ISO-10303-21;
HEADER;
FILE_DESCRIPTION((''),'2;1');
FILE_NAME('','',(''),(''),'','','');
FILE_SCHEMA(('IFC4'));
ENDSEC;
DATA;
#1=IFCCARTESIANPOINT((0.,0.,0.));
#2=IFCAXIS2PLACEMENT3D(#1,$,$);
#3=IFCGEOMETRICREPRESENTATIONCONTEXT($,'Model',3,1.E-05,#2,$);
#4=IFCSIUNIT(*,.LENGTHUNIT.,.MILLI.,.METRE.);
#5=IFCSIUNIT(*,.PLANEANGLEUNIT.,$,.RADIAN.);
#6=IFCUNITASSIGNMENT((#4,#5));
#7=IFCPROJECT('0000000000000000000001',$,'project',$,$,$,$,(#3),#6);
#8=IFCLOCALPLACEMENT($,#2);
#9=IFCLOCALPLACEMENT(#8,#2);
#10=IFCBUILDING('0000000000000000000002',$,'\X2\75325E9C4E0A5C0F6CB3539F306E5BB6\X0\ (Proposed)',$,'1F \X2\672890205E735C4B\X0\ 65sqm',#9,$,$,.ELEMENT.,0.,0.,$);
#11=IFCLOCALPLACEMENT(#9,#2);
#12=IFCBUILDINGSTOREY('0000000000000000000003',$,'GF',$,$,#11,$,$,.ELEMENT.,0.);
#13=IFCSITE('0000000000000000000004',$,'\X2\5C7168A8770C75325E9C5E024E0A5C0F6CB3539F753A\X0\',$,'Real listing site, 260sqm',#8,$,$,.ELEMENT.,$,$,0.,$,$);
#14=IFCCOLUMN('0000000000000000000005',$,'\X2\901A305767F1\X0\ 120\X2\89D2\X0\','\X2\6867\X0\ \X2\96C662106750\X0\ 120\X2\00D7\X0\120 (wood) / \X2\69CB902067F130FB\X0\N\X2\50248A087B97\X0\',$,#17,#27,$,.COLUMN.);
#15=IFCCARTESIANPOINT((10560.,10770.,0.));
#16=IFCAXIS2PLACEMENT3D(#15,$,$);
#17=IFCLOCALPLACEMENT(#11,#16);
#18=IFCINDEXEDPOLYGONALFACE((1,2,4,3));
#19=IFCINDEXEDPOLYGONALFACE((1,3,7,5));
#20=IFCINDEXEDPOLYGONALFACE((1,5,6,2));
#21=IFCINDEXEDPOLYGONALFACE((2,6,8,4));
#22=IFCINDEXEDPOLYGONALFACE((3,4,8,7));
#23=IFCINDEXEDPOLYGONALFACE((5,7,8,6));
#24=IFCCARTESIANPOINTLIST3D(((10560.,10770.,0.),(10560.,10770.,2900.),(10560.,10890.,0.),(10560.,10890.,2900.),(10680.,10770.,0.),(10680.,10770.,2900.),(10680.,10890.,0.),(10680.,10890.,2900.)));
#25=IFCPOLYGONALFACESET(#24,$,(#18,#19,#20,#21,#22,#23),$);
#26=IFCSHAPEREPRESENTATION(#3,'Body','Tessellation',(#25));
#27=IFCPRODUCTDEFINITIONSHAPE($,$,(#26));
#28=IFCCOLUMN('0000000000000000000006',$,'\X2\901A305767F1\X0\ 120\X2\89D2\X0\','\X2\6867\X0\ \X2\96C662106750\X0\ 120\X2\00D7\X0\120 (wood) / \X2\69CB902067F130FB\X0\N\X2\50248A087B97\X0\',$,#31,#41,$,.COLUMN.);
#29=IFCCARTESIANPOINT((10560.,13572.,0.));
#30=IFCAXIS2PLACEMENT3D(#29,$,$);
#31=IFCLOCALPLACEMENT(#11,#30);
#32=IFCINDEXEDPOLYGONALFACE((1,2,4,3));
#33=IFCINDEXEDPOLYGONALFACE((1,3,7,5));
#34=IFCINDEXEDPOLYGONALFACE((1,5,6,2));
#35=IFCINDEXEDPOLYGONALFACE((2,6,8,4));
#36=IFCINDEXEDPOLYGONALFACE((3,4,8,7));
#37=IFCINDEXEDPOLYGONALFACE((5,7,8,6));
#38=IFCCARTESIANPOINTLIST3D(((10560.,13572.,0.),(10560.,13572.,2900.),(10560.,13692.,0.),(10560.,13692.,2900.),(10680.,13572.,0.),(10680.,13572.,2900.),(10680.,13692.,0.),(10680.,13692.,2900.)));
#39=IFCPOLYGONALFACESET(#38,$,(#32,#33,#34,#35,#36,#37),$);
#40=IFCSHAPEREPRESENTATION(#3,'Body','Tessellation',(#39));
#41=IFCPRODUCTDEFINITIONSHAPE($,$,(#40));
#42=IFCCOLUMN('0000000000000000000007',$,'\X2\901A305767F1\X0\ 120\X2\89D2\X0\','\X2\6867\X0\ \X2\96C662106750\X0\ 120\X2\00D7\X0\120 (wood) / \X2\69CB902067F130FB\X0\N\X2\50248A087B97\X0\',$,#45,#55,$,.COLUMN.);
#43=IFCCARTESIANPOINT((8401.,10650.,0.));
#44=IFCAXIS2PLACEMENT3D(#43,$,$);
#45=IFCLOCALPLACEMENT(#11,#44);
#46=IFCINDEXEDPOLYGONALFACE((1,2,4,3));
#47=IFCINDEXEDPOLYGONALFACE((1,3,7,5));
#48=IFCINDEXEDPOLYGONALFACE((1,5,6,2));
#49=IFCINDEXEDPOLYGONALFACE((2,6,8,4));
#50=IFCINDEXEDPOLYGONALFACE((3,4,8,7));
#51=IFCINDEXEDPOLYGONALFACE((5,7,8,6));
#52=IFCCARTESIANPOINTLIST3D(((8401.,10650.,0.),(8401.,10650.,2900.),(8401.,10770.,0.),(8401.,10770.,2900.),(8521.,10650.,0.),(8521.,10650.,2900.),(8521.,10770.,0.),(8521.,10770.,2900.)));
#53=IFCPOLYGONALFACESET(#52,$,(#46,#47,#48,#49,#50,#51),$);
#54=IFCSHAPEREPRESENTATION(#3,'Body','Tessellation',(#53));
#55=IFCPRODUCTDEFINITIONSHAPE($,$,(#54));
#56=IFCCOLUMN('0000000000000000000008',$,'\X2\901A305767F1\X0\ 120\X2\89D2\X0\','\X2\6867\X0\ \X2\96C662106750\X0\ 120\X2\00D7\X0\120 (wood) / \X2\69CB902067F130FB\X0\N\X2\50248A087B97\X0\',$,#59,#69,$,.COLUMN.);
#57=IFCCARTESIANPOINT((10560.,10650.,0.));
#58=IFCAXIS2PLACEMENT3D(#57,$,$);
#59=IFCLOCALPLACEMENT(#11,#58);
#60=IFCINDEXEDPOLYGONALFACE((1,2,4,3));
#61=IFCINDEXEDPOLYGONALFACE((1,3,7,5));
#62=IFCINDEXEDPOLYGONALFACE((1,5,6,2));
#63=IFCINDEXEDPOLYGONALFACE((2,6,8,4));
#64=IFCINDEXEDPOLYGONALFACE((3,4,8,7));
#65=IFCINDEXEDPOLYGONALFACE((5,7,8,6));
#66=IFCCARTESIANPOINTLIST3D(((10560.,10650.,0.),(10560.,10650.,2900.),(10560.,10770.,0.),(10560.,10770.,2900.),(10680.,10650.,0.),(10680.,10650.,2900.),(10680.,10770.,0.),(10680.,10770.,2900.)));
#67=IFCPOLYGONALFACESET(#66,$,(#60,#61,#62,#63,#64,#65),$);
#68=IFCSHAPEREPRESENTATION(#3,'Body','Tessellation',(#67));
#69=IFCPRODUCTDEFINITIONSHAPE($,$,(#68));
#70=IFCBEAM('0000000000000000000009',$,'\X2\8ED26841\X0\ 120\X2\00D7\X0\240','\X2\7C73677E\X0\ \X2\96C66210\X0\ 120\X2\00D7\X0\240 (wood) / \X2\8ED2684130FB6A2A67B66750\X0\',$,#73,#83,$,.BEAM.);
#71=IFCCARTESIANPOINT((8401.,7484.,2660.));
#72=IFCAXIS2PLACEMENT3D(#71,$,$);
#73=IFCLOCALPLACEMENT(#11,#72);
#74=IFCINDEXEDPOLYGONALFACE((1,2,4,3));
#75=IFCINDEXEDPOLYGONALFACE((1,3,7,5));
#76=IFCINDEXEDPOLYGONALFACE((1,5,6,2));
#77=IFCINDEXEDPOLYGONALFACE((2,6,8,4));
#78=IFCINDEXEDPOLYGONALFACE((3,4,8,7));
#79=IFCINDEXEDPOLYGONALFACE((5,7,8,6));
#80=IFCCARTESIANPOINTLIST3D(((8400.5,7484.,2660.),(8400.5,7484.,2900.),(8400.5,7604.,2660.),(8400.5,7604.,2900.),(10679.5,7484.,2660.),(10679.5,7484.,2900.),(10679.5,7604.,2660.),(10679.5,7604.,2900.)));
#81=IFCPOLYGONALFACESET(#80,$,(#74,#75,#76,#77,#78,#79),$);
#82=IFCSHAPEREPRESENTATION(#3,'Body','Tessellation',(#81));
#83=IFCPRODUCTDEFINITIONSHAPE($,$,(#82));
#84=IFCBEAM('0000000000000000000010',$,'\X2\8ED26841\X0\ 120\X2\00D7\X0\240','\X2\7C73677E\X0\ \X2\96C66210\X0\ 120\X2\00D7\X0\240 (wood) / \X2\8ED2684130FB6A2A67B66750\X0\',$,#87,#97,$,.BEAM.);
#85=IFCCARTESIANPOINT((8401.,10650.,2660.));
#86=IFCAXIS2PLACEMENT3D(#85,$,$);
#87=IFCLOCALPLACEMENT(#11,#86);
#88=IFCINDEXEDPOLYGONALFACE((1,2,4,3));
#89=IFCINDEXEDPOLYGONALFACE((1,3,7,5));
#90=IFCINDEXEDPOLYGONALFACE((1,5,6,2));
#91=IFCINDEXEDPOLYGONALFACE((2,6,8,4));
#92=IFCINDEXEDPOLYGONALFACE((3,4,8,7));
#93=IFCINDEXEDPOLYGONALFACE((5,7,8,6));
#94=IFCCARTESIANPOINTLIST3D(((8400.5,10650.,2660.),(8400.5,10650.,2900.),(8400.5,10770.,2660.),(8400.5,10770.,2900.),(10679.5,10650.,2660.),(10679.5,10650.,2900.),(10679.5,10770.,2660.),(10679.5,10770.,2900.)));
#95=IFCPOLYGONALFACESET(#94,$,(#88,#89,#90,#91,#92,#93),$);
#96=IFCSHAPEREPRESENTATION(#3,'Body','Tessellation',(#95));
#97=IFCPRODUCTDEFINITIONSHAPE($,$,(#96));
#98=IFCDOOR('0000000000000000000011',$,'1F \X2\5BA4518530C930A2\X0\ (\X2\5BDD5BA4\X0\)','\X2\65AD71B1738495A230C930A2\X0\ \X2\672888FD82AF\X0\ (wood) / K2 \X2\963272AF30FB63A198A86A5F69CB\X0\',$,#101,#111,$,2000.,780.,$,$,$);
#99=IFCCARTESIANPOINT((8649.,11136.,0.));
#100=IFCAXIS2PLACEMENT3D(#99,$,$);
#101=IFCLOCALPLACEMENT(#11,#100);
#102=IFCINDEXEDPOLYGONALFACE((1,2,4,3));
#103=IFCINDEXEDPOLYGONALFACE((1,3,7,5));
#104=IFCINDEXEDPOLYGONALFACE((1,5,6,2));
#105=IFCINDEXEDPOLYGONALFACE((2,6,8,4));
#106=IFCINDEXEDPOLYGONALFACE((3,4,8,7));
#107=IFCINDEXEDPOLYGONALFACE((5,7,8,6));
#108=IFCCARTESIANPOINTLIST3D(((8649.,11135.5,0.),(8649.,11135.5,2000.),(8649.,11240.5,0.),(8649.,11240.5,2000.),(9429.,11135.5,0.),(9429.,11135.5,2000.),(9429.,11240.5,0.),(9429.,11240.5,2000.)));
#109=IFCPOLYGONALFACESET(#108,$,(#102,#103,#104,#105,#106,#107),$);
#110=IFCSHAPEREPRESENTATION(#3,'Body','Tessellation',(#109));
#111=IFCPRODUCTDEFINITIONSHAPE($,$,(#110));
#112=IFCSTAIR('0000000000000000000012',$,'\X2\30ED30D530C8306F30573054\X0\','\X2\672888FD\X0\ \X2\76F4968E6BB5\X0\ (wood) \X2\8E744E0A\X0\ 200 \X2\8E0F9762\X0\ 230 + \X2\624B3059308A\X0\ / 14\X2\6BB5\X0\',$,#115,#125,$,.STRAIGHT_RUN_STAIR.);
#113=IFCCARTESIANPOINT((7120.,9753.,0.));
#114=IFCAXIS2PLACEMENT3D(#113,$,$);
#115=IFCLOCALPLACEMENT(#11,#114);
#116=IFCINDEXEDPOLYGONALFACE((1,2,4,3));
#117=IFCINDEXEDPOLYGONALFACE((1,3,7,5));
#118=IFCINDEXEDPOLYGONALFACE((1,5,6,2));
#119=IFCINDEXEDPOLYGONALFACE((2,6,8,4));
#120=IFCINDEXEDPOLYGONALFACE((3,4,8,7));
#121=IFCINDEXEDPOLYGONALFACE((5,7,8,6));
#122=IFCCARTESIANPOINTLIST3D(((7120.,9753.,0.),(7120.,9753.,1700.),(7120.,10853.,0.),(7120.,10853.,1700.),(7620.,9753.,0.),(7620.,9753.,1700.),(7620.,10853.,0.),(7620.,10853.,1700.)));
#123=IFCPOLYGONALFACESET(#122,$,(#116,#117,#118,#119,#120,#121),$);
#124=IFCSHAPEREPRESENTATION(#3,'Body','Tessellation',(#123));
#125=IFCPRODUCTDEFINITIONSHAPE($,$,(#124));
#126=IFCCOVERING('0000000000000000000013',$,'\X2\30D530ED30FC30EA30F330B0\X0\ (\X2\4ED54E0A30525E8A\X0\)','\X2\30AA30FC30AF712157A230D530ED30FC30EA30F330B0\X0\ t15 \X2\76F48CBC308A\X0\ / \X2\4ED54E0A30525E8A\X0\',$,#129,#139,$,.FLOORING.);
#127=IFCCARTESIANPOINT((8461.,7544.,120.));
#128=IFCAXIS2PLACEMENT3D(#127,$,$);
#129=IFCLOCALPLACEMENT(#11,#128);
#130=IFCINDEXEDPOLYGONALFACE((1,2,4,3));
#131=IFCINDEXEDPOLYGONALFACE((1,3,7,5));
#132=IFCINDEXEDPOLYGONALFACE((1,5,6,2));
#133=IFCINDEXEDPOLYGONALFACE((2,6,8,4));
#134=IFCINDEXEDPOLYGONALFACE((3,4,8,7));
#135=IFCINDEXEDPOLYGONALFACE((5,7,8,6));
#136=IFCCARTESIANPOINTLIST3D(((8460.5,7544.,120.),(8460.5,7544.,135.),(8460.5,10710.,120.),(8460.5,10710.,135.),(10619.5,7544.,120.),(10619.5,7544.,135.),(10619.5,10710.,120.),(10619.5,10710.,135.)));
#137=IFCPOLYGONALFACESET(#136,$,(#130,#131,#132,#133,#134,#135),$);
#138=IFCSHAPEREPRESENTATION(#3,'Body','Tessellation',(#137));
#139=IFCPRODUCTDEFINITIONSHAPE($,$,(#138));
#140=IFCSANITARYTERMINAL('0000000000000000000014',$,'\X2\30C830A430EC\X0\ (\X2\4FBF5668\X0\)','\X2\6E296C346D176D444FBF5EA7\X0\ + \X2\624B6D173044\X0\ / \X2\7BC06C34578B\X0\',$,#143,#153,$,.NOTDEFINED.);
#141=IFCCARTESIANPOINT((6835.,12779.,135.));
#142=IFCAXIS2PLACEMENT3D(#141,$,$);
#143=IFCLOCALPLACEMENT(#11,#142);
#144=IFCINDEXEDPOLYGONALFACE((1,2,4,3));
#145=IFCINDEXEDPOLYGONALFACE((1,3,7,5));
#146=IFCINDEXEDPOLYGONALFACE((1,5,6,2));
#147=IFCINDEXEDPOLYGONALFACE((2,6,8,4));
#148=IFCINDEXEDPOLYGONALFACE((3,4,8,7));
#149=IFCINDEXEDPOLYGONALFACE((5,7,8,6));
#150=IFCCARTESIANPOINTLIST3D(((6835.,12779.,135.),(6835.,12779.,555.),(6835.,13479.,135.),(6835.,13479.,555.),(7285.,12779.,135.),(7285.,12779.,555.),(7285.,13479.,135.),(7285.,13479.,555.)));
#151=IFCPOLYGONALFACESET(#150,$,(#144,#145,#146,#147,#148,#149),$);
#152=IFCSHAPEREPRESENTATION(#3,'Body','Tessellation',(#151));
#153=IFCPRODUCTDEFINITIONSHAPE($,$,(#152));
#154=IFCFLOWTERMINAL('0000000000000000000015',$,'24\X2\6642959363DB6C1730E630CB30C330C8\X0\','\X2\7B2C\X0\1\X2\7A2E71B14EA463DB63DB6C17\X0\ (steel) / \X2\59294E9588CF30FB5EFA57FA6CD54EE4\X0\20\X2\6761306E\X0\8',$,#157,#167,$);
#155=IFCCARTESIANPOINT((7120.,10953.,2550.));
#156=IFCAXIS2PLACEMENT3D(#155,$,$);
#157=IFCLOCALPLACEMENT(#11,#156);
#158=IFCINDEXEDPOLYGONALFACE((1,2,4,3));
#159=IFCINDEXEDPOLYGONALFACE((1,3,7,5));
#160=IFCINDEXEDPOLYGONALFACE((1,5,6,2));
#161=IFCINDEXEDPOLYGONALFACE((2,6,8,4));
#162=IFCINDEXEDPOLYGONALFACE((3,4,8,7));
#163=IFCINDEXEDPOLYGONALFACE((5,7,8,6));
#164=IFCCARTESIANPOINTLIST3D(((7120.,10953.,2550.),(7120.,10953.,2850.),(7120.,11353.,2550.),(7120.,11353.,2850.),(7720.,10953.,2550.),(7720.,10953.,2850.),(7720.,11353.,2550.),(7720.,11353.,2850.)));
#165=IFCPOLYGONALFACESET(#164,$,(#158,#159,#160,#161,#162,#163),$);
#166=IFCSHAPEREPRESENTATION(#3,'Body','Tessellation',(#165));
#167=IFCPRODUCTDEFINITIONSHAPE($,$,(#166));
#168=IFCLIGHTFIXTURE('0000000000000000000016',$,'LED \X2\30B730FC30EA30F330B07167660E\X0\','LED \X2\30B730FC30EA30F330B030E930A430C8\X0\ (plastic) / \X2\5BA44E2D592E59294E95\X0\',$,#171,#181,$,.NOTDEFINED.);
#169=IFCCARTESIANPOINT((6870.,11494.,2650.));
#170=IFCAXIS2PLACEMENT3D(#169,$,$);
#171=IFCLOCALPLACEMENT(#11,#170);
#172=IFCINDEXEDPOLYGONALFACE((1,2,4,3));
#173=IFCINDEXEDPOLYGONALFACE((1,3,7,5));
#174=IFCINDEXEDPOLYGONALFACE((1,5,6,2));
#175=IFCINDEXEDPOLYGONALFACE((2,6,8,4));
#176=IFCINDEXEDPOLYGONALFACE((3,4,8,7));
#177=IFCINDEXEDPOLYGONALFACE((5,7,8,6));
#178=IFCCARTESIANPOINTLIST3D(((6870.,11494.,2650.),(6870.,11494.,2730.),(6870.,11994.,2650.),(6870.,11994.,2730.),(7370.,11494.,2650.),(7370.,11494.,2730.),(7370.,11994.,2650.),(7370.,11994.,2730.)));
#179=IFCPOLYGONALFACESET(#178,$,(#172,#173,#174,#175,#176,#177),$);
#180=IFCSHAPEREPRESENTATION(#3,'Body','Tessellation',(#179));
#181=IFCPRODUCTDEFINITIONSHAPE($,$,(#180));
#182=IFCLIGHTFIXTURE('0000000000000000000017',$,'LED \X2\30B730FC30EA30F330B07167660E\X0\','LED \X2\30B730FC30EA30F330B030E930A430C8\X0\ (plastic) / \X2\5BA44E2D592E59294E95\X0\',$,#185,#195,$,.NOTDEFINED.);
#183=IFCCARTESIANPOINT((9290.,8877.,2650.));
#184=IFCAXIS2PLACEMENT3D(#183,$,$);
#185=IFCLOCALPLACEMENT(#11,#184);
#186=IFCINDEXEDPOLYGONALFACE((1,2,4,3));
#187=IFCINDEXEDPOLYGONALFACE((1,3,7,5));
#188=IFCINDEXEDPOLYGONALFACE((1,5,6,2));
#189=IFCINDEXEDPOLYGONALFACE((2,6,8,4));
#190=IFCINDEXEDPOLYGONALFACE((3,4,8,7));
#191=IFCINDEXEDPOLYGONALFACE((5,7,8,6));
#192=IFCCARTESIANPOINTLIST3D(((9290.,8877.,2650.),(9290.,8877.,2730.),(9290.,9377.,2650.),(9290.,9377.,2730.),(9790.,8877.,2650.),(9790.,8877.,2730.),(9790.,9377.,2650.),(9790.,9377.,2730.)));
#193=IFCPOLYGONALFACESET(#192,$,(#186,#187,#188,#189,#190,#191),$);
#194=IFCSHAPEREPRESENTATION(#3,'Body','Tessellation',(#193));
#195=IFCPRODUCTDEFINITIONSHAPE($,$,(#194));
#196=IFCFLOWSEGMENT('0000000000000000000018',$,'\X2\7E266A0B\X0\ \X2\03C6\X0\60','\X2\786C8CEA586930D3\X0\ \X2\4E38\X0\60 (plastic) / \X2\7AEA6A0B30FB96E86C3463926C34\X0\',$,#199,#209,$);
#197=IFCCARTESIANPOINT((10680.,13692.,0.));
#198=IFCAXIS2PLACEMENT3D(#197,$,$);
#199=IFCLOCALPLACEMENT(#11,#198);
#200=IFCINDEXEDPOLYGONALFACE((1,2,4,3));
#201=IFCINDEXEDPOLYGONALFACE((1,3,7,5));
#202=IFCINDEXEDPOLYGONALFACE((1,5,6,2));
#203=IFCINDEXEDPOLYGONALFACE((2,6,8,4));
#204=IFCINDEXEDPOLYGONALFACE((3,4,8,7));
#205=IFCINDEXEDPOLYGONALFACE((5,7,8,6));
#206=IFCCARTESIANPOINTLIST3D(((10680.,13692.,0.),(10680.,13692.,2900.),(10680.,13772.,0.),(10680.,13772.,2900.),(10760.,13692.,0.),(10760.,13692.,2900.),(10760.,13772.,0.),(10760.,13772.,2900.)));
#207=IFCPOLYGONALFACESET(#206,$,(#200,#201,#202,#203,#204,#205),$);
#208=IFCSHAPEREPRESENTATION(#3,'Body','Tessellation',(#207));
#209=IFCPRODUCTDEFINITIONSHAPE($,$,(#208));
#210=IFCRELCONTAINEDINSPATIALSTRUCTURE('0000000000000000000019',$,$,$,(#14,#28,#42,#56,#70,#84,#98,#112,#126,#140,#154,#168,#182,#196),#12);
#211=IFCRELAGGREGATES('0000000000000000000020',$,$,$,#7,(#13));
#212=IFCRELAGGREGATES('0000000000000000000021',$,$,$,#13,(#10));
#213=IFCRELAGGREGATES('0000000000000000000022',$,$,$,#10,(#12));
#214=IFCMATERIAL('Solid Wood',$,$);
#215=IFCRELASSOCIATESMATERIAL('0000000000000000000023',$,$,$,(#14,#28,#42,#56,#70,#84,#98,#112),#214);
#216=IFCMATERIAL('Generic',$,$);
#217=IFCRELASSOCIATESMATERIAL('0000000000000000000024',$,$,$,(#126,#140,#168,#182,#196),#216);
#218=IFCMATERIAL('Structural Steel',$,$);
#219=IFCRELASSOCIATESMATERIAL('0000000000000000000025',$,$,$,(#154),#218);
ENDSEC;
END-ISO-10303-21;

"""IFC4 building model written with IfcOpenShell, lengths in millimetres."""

from ifc_helpers import new_model, si_unit, frame, frame_2d, origin, place, context, project, spatial, rectangle, extrude, material, element, save


model = new_model("IFC4")

# Units and contexts
model_context = context("Model", 3, precision=1e-05, world=origin())
ifc_project = project(units=[si_unit("LENGTHUNIT", "METRE", prefix="MILLI"), si_unit("PLANEANGLEUNIT", "RADIAN")], contexts=[model_context])

# Site, building, storey
site_placement = place(None, origin())
site = spatial("IfcSite", under=ifc_project, at=site_placement, Name="山梨県甲府市上小河原町", ObjectType="Real listing site, 260sqm", CompositionType="ELEMENT", RefElevation=0.0)
building_placement = place(site_placement, origin())
building = spatial("IfcBuilding", under=site, at=building_placement, Name="甲府上小河原の家 (Proposed)", ObjectType="1F 木造平屋 65sqm", CompositionType="ELEMENT", ElevationOfRefHeight=0.0, ElevationOfTerrain=0.0)
storey_placement = place(building_placement, origin())
storey = spatial("IfcBuildingStorey", under=building, at=storey_placement, Name="GF", CompositionType="ELEMENT", Elevation=0.0)

# Columns
ifc_material_1 = material(Name="Solid Wood")
column_1_placement = place(storey_placement, frame((10560.0, 10770.0, 0.0)))
element("IfcColumn", 1, at=column_1_placement, inside=storey, material=ifc_material_1, Name="通し柱 120角", Description="桧 集成材 120×120 (wood) / 構造柱・N値計算", PredefinedType="COLUMN", context=model_context, shape_type="SweptSolid", body=[
    extrude(rectangle(XDim=120.0, YDim=120.0, at=frame_2d((60.0, 60.0))), frame((10560.0, 10770.0, 0.0)), (0.0, 0.0, 1.0), 2900.0),
])
column_2_placement = place(storey_placement, frame((10560.0, 13572.0, 0.0)))
element("IfcColumn", 2, at=column_2_placement, inside=storey, material=ifc_material_1, Name="通し柱 120角", Description="桧 集成材 120×120 (wood) / 構造柱・N値計算", PredefinedType="COLUMN", context=model_context, shape_type="SweptSolid", body=[
    extrude(rectangle(XDim=120.0, YDim=120.0, at=frame_2d((60.0, 60.0))), frame((10560.0, 13572.0, 0.0)), (0.0, 0.0, 1.0), 2900.0),
])
column_3_placement = place(storey_placement, frame((8401.0, 10650.0, 0.0)))
element("IfcColumn", 3, at=column_3_placement, inside=storey, material=ifc_material_1, Name="通し柱 120角", Description="桧 集成材 120×120 (wood) / 構造柱・N値計算", PredefinedType="COLUMN", context=model_context, shape_type="SweptSolid", body=[
    extrude(rectangle(XDim=120.0, YDim=120.0, at=frame_2d((60.0, 60.0))), frame((8401.0, 10650.0, 0.0)), (0.0, 0.0, 1.0), 2900.0),
])
column_4_placement = place(storey_placement, frame((10560.0, 10650.0, 0.0)))
element("IfcColumn", 4, at=column_4_placement, inside=storey, material=ifc_material_1, Name="通し柱 120角", Description="桧 集成材 120×120 (wood) / 構造柱・N値計算", PredefinedType="COLUMN", context=model_context, shape_type="SweptSolid", body=[
    extrude(rectangle(XDim=120.0, YDim=120.0, at=frame_2d((60.0, 60.0))), frame((10560.0, 10650.0, 0.0)), (0.0, 0.0, 1.0), 2900.0),
])

# Beams
beam_1_placement = place(storey_placement, frame((8401.0, 7484.0, 2660.0)))
element("IfcBeam", 5, at=beam_1_placement, inside=storey, material=ifc_material_1, Name="軒桁 120×240", Description="米松 集成 120×240 (wood) / 軒桁・横架材", PredefinedType="BEAM", context=model_context, shape_type="SweptSolid", body=[
    extrude(rectangle(XDim=2279.0, YDim=120.0, at=frame_2d((1139.0, 60.0))), frame((8401.0, 7484.0, 2660.0)), (0.0, 0.0, 1.0), 240.0),
])
beam_2_placement = place(storey_placement, frame((8401.0, 10650.0, 2660.0)))
element("IfcBeam", 6, at=beam_2_placement, inside=storey, material=ifc_material_1, Name="軒桁 120×240", Description="米松 集成 120×240 (wood) / 軒桁・横架材", PredefinedType="BEAM", context=model_context, shape_type="SweptSolid", body=[
    extrude(rectangle(XDim=2279.0, YDim=120.0, at=frame_2d((1139.0, 60.0))), frame((8401.0, 10650.0, 2660.0)), (0.0, 0.0, 1.0), 240.0),
])

# Door
door_placement = place(storey_placement, frame((8649.0, 11136.0, 0.0)))
element("IfcDoor", 7, at=door_placement, inside=storey, material=ifc_material_1, Name="1F 室内ドア (寝室)", Description="断熱玄関ドア 木製芯 (wood) / K2 防犯・採風機構", OverallHeight=2000.0, OverallWidth=780.0, context=model_context, shape_type="SweptSolid", body=[
    extrude(rectangle(XDim=780.0, YDim=105.0, at=frame_2d((390.0, 52.0))), frame((8649.0, 11136.0, 0.0)), (0.0, 0.0, 1.0), 2000.0),
])

# Stair
stair_placement = place(storey_placement, frame((7120.0, 9753.0, 0.0)))
element("IfcStair", 8, at=stair_placement, inside=storey, material=ifc_material_1, Name="ロフトはしご", Description="木製 直階段 (wood) 蹴上 200 踏面 230 + 手すり / 14段", PredefinedType="STRAIGHT_RUN_STAIR", context=model_context, shape_type="SweptSolid", body=[
    extrude(rectangle(XDim=500.0, YDim=1100.0, at=frame_2d((250.0, 550.0))), frame((7120.0, 9753.0, 0.0)), (0.0, 0.0, 1.0), 1700.0),
])

# Covering
ifc_material_2 = material(Name="Generic")
covering_placement = place(storey_placement, frame((8461.0, 7544.0, 120.0)))
element("IfcCovering", 9, at=covering_placement, inside=storey, material=ifc_material_2, Name="フローリング (仕上げ床)", Description="オーク無垢フローリング t15 直貼り / 仕上げ床", PredefinedType="FLOORING", context=model_context, shape_type="SweptSolid", body=[
    extrude(rectangle(XDim=2159.0, YDim=3166.0, at=frame_2d((1079.0, 1583.0))), frame((8461.0, 7544.0, 120.0)), (0.0, 0.0, 1.0), 15.0),
])

# Sanitary terminal
sanitary_terminal_placement = place(storey_placement, frame((6835.0, 12779.0, 135.0)))
element("IfcSanitaryTerminal", 10, at=sanitary_terminal_placement, inside=storey, material=ifc_material_2, Name="トイレ (便器)", Description="温水洗浄便座 + 手洗い / 節水型", PredefinedType="NOTDEFINED", context=model_context, shape_type="SweptSolid", body=[
    extrude(rectangle(XDim=450.0, YDim=700.0, at=frame_2d((225.0, 350.0))), frame((6835.0, 12779.0, 135.0)), (0.0, 0.0, 1.0), 420.0),
])

# Flow terminal
ifc_material_3 = material(Name="Structural Steel")
flow_terminal_placement = place(storey_placement, frame((7120.0, 10953.0, 2550.0)))
element("IfcFlowTerminal", 11, at=flow_terminal_placement, inside=storey, material=ifc_material_3, Name="24時間換気ユニット", Description="第1種熱交換換気 (steel) / 天井裏・建基法令20条の8", context=model_context, shape_type="SweptSolid", body=[
    extrude(rectangle(XDim=600.0, YDim=400.0, at=frame_2d((300.0, 200.0))), frame((7120.0, 10953.0, 2550.0)), (0.0, 0.0, 1.0), 300.0),
])

# Light fixtures
light_fixture_1_placement = place(storey_placement, frame((6870.0, 11494.0, 2650.0)))
element("IfcLightFixture", 12, at=light_fixture_1_placement, inside=storey, material=ifc_material_2, Name="LED シーリング照明", Description="LED シーリングライト (plastic) / 室中央天井", PredefinedType="NOTDEFINED", context=model_context, shape_type="SweptSolid", body=[
    extrude(rectangle(XDim=500.0, YDim=500.0, at=frame_2d((250.0, 250.0))), frame((6870.0, 11494.0, 2650.0)), (0.0, 0.0, 1.0), 80.0),
])
light_fixture_2_placement = place(storey_placement, frame((9290.0, 8877.0, 2650.0)))
element("IfcLightFixture", 13, at=light_fixture_2_placement, inside=storey, material=ifc_material_2, Name="LED シーリング照明", Description="LED シーリングライト (plastic) / 室中央天井", PredefinedType="NOTDEFINED", context=model_context, shape_type="SweptSolid", body=[
    extrude(rectangle(XDim=500.0, YDim=500.0, at=frame_2d((250.0, 250.0))), frame((9290.0, 8877.0, 2650.0)), (0.0, 0.0, 1.0), 80.0),
])

# Flow segment
flow_segment_placement = place(storey_placement, frame((10680.0, 13692.0, 0.0)))
element("IfcFlowSegment", 14, at=flow_segment_placement, inside=storey, material=ifc_material_2, Name="縦樋 φ60", Description="硬質塩ビ 丸60 (plastic) / 竪樋・雨水排水", context=model_context, shape_type="SweptSolid", body=[
    extrude(rectangle(XDim=80.0, YDim=80.0, at=frame_2d((40.0, 40.0))), frame((10680.0, 13692.0, 0.0)), (0.0, 0.0, 1.0), 2900.0),
])

save(model, "model.ifc")
